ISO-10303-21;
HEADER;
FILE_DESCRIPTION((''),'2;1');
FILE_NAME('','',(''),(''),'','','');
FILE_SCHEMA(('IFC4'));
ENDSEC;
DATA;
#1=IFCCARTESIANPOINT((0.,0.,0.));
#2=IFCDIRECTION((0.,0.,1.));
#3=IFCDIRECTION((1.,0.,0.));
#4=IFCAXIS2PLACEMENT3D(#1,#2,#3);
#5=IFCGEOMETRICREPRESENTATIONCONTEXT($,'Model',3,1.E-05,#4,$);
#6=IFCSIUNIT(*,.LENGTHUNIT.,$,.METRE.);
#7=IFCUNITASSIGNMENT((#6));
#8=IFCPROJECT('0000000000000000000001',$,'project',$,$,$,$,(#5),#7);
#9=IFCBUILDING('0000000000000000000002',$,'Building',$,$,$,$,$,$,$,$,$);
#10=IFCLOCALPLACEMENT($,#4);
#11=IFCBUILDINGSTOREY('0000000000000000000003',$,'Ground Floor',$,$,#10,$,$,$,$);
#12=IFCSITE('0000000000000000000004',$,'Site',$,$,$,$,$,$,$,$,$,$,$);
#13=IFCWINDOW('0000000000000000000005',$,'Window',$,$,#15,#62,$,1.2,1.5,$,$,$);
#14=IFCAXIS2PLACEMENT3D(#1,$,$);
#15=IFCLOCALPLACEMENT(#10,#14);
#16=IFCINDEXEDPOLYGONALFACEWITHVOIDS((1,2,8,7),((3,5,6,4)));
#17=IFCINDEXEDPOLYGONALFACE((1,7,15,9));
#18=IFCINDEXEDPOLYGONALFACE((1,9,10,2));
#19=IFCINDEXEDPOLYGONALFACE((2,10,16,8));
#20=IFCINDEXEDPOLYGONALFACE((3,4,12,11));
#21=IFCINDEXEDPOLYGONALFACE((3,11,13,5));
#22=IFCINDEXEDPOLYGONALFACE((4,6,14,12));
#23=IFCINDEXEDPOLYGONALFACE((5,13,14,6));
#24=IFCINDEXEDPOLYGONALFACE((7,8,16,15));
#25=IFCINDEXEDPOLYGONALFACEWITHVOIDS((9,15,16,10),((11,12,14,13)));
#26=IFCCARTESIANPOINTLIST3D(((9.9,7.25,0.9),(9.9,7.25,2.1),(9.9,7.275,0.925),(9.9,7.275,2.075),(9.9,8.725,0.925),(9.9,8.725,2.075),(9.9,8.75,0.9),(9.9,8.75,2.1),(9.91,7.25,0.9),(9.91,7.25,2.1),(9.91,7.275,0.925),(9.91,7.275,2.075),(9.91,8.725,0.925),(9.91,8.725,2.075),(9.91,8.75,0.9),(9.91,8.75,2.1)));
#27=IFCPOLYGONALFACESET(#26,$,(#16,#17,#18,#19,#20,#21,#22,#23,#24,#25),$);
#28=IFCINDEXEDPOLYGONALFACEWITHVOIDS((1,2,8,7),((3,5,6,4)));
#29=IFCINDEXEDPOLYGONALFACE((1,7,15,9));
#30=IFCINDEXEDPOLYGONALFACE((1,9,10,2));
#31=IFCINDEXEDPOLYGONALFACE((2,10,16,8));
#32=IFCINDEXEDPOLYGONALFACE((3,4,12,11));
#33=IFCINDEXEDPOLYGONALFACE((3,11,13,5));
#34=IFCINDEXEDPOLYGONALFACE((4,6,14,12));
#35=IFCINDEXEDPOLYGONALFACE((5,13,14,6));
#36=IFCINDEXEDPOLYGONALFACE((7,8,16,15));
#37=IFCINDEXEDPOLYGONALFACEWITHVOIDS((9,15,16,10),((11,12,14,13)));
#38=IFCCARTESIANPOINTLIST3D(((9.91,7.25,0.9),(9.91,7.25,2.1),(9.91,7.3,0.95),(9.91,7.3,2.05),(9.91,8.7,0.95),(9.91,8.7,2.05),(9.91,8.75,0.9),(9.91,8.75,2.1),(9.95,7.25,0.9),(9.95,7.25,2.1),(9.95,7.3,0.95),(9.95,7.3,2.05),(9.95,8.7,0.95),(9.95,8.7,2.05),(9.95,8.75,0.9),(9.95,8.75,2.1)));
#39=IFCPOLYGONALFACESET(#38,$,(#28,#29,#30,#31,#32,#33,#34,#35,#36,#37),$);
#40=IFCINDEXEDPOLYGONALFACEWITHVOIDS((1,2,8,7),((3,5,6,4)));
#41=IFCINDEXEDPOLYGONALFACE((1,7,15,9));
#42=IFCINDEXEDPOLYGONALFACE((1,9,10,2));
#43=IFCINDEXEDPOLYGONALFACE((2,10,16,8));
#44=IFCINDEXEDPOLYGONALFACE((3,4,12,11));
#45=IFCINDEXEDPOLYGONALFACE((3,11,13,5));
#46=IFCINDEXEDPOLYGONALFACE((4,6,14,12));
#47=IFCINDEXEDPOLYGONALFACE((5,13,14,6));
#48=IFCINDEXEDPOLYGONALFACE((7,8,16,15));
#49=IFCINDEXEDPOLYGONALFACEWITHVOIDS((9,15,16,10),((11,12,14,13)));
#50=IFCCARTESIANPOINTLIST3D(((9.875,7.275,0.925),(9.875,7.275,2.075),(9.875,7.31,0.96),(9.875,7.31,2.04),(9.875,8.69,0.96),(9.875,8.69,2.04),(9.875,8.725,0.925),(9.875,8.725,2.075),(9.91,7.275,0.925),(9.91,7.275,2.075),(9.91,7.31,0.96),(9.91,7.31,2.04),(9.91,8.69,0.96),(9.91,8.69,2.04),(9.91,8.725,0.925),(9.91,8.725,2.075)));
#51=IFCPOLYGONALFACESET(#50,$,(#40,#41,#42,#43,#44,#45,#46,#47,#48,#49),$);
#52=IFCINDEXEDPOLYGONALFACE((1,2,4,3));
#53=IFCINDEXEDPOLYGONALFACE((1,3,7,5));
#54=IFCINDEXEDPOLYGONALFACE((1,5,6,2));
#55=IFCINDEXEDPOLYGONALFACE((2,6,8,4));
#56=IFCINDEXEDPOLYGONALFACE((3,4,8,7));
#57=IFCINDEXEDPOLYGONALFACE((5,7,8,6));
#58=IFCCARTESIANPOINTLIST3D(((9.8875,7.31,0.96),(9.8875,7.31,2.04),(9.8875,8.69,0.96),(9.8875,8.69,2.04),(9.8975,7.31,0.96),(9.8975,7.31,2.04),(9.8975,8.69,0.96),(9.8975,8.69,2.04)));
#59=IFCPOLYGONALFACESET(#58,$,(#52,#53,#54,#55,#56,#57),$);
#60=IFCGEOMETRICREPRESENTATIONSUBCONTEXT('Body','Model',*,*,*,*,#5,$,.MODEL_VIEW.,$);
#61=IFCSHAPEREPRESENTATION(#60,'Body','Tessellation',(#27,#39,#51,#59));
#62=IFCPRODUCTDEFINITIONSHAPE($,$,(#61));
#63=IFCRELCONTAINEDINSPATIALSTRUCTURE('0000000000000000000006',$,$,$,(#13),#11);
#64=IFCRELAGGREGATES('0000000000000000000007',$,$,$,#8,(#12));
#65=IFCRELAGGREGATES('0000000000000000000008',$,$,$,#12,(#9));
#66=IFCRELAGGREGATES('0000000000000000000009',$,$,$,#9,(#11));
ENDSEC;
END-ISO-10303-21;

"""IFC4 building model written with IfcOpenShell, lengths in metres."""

from ifc_helpers import new_model, si_unit, frame, origin_with_axes, place, context, subcontext, project, spatial, line, indexed_curve, outline, extrude, element, save


model = new_model("IFC4")

# Units and contexts
model_context = context("Model", 3, precision=1e-05, world=origin_with_axes())
body_context = subcontext(model_context, "Body", "Model", "MODEL_VIEW")
ifc_project = project(units=[si_unit("LENGTHUNIT", "METRE")], contexts=[model_context])

# Site, building, storey
site = spatial("IfcSite", under=ifc_project, Name="Site")
building = spatial("IfcBuilding", under=site, Name="Building")
storey_placement = place(None, origin_with_axes())
storey = spatial("IfcBuildingStorey", under=building, at=storey_placement, Name="Ground Floor")

# Window
window_1_placement = place(storey_placement, frame((10.0, 7.25, 0.9), z_axis=(0.0, 0.0, 1.0), x_axis=(0.0, 1.0, 0.0)))
element("IfcWindow", 1, at=window_1_placement, inside=storey, Name="Window", OverallHeight=1.2, OverallWidth=1.5, context=body_context, shape_type="SweptSolid", body=[
    extrude(outline(indexed_curve([(0.0, 0.0), (1.5, 0.0), (1.5, 1.2), (0.0, 1.2)], segments=[line(1, 2, 3, 4, 1)]), holes=[indexed_curve([(0.025, 0.025), (1.475, 0.025), (1.475, 1.175), (0.025, 1.175)], segments=[line(1, 2, 3, 4, 1)])]), frame((0.0, 0.09, 0.0), z_axis=(0.0, -1.0, 0.0), x_axis=(1.0, 0.0, 0.0)), (0.0, 0.0, -1.0), 0.01),
    extrude(outline(indexed_curve([(0.0, 0.0), (1.5, 0.0), (1.5, 1.2), (0.0, 1.2)], segments=[line(1, 2, 3, 4, 1)]), holes=[indexed_curve([(0.05, 0.05), (1.45, 0.05), (1.45, 1.15), (0.05, 1.15)], segments=[line(1, 2, 3, 4, 1)])]), frame((0.0, 0.05, 0.0), z_axis=(0.0, -1.0, 0.0), x_axis=(1.0, 0.0, 0.0)), (0.0, 0.0, -1.0), 0.04),
    extrude(outline(indexed_curve([(0.0, 0.0), (1.45, 0.0), (1.45, 1.15), (0.0, 1.15)], segments=[line(1, 2, 3, 4, 1)]), holes=[indexed_curve([(0.035, 0.035), (1.415, 0.035), (1.415, 1.115), (0.035, 1.115)], segments=[line(1, 2, 3, 4, 1)])]), frame((0.025, 0.09, 0.025), z_axis=(0.0, -1.0, 0.0), x_axis=(1.0, 0.0, 0.0)), (0.0, 0.0, -1.0), 0.035),
    extrude(outline(indexed_curve([(0.035, 0.035), (1.415, 0.035), (1.415, 1.115), (0.035, 1.115)], segments=[line(1, 2, 3, 4, 1)])), frame((0.025, 0.1025, 0.025), z_axis=(0.0, -1.0, 0.0), x_axis=(1.0, 0.0, 0.0)), (0.0, 0.0, -1.0), 0.01),
])

save(model, "model.ifc")
